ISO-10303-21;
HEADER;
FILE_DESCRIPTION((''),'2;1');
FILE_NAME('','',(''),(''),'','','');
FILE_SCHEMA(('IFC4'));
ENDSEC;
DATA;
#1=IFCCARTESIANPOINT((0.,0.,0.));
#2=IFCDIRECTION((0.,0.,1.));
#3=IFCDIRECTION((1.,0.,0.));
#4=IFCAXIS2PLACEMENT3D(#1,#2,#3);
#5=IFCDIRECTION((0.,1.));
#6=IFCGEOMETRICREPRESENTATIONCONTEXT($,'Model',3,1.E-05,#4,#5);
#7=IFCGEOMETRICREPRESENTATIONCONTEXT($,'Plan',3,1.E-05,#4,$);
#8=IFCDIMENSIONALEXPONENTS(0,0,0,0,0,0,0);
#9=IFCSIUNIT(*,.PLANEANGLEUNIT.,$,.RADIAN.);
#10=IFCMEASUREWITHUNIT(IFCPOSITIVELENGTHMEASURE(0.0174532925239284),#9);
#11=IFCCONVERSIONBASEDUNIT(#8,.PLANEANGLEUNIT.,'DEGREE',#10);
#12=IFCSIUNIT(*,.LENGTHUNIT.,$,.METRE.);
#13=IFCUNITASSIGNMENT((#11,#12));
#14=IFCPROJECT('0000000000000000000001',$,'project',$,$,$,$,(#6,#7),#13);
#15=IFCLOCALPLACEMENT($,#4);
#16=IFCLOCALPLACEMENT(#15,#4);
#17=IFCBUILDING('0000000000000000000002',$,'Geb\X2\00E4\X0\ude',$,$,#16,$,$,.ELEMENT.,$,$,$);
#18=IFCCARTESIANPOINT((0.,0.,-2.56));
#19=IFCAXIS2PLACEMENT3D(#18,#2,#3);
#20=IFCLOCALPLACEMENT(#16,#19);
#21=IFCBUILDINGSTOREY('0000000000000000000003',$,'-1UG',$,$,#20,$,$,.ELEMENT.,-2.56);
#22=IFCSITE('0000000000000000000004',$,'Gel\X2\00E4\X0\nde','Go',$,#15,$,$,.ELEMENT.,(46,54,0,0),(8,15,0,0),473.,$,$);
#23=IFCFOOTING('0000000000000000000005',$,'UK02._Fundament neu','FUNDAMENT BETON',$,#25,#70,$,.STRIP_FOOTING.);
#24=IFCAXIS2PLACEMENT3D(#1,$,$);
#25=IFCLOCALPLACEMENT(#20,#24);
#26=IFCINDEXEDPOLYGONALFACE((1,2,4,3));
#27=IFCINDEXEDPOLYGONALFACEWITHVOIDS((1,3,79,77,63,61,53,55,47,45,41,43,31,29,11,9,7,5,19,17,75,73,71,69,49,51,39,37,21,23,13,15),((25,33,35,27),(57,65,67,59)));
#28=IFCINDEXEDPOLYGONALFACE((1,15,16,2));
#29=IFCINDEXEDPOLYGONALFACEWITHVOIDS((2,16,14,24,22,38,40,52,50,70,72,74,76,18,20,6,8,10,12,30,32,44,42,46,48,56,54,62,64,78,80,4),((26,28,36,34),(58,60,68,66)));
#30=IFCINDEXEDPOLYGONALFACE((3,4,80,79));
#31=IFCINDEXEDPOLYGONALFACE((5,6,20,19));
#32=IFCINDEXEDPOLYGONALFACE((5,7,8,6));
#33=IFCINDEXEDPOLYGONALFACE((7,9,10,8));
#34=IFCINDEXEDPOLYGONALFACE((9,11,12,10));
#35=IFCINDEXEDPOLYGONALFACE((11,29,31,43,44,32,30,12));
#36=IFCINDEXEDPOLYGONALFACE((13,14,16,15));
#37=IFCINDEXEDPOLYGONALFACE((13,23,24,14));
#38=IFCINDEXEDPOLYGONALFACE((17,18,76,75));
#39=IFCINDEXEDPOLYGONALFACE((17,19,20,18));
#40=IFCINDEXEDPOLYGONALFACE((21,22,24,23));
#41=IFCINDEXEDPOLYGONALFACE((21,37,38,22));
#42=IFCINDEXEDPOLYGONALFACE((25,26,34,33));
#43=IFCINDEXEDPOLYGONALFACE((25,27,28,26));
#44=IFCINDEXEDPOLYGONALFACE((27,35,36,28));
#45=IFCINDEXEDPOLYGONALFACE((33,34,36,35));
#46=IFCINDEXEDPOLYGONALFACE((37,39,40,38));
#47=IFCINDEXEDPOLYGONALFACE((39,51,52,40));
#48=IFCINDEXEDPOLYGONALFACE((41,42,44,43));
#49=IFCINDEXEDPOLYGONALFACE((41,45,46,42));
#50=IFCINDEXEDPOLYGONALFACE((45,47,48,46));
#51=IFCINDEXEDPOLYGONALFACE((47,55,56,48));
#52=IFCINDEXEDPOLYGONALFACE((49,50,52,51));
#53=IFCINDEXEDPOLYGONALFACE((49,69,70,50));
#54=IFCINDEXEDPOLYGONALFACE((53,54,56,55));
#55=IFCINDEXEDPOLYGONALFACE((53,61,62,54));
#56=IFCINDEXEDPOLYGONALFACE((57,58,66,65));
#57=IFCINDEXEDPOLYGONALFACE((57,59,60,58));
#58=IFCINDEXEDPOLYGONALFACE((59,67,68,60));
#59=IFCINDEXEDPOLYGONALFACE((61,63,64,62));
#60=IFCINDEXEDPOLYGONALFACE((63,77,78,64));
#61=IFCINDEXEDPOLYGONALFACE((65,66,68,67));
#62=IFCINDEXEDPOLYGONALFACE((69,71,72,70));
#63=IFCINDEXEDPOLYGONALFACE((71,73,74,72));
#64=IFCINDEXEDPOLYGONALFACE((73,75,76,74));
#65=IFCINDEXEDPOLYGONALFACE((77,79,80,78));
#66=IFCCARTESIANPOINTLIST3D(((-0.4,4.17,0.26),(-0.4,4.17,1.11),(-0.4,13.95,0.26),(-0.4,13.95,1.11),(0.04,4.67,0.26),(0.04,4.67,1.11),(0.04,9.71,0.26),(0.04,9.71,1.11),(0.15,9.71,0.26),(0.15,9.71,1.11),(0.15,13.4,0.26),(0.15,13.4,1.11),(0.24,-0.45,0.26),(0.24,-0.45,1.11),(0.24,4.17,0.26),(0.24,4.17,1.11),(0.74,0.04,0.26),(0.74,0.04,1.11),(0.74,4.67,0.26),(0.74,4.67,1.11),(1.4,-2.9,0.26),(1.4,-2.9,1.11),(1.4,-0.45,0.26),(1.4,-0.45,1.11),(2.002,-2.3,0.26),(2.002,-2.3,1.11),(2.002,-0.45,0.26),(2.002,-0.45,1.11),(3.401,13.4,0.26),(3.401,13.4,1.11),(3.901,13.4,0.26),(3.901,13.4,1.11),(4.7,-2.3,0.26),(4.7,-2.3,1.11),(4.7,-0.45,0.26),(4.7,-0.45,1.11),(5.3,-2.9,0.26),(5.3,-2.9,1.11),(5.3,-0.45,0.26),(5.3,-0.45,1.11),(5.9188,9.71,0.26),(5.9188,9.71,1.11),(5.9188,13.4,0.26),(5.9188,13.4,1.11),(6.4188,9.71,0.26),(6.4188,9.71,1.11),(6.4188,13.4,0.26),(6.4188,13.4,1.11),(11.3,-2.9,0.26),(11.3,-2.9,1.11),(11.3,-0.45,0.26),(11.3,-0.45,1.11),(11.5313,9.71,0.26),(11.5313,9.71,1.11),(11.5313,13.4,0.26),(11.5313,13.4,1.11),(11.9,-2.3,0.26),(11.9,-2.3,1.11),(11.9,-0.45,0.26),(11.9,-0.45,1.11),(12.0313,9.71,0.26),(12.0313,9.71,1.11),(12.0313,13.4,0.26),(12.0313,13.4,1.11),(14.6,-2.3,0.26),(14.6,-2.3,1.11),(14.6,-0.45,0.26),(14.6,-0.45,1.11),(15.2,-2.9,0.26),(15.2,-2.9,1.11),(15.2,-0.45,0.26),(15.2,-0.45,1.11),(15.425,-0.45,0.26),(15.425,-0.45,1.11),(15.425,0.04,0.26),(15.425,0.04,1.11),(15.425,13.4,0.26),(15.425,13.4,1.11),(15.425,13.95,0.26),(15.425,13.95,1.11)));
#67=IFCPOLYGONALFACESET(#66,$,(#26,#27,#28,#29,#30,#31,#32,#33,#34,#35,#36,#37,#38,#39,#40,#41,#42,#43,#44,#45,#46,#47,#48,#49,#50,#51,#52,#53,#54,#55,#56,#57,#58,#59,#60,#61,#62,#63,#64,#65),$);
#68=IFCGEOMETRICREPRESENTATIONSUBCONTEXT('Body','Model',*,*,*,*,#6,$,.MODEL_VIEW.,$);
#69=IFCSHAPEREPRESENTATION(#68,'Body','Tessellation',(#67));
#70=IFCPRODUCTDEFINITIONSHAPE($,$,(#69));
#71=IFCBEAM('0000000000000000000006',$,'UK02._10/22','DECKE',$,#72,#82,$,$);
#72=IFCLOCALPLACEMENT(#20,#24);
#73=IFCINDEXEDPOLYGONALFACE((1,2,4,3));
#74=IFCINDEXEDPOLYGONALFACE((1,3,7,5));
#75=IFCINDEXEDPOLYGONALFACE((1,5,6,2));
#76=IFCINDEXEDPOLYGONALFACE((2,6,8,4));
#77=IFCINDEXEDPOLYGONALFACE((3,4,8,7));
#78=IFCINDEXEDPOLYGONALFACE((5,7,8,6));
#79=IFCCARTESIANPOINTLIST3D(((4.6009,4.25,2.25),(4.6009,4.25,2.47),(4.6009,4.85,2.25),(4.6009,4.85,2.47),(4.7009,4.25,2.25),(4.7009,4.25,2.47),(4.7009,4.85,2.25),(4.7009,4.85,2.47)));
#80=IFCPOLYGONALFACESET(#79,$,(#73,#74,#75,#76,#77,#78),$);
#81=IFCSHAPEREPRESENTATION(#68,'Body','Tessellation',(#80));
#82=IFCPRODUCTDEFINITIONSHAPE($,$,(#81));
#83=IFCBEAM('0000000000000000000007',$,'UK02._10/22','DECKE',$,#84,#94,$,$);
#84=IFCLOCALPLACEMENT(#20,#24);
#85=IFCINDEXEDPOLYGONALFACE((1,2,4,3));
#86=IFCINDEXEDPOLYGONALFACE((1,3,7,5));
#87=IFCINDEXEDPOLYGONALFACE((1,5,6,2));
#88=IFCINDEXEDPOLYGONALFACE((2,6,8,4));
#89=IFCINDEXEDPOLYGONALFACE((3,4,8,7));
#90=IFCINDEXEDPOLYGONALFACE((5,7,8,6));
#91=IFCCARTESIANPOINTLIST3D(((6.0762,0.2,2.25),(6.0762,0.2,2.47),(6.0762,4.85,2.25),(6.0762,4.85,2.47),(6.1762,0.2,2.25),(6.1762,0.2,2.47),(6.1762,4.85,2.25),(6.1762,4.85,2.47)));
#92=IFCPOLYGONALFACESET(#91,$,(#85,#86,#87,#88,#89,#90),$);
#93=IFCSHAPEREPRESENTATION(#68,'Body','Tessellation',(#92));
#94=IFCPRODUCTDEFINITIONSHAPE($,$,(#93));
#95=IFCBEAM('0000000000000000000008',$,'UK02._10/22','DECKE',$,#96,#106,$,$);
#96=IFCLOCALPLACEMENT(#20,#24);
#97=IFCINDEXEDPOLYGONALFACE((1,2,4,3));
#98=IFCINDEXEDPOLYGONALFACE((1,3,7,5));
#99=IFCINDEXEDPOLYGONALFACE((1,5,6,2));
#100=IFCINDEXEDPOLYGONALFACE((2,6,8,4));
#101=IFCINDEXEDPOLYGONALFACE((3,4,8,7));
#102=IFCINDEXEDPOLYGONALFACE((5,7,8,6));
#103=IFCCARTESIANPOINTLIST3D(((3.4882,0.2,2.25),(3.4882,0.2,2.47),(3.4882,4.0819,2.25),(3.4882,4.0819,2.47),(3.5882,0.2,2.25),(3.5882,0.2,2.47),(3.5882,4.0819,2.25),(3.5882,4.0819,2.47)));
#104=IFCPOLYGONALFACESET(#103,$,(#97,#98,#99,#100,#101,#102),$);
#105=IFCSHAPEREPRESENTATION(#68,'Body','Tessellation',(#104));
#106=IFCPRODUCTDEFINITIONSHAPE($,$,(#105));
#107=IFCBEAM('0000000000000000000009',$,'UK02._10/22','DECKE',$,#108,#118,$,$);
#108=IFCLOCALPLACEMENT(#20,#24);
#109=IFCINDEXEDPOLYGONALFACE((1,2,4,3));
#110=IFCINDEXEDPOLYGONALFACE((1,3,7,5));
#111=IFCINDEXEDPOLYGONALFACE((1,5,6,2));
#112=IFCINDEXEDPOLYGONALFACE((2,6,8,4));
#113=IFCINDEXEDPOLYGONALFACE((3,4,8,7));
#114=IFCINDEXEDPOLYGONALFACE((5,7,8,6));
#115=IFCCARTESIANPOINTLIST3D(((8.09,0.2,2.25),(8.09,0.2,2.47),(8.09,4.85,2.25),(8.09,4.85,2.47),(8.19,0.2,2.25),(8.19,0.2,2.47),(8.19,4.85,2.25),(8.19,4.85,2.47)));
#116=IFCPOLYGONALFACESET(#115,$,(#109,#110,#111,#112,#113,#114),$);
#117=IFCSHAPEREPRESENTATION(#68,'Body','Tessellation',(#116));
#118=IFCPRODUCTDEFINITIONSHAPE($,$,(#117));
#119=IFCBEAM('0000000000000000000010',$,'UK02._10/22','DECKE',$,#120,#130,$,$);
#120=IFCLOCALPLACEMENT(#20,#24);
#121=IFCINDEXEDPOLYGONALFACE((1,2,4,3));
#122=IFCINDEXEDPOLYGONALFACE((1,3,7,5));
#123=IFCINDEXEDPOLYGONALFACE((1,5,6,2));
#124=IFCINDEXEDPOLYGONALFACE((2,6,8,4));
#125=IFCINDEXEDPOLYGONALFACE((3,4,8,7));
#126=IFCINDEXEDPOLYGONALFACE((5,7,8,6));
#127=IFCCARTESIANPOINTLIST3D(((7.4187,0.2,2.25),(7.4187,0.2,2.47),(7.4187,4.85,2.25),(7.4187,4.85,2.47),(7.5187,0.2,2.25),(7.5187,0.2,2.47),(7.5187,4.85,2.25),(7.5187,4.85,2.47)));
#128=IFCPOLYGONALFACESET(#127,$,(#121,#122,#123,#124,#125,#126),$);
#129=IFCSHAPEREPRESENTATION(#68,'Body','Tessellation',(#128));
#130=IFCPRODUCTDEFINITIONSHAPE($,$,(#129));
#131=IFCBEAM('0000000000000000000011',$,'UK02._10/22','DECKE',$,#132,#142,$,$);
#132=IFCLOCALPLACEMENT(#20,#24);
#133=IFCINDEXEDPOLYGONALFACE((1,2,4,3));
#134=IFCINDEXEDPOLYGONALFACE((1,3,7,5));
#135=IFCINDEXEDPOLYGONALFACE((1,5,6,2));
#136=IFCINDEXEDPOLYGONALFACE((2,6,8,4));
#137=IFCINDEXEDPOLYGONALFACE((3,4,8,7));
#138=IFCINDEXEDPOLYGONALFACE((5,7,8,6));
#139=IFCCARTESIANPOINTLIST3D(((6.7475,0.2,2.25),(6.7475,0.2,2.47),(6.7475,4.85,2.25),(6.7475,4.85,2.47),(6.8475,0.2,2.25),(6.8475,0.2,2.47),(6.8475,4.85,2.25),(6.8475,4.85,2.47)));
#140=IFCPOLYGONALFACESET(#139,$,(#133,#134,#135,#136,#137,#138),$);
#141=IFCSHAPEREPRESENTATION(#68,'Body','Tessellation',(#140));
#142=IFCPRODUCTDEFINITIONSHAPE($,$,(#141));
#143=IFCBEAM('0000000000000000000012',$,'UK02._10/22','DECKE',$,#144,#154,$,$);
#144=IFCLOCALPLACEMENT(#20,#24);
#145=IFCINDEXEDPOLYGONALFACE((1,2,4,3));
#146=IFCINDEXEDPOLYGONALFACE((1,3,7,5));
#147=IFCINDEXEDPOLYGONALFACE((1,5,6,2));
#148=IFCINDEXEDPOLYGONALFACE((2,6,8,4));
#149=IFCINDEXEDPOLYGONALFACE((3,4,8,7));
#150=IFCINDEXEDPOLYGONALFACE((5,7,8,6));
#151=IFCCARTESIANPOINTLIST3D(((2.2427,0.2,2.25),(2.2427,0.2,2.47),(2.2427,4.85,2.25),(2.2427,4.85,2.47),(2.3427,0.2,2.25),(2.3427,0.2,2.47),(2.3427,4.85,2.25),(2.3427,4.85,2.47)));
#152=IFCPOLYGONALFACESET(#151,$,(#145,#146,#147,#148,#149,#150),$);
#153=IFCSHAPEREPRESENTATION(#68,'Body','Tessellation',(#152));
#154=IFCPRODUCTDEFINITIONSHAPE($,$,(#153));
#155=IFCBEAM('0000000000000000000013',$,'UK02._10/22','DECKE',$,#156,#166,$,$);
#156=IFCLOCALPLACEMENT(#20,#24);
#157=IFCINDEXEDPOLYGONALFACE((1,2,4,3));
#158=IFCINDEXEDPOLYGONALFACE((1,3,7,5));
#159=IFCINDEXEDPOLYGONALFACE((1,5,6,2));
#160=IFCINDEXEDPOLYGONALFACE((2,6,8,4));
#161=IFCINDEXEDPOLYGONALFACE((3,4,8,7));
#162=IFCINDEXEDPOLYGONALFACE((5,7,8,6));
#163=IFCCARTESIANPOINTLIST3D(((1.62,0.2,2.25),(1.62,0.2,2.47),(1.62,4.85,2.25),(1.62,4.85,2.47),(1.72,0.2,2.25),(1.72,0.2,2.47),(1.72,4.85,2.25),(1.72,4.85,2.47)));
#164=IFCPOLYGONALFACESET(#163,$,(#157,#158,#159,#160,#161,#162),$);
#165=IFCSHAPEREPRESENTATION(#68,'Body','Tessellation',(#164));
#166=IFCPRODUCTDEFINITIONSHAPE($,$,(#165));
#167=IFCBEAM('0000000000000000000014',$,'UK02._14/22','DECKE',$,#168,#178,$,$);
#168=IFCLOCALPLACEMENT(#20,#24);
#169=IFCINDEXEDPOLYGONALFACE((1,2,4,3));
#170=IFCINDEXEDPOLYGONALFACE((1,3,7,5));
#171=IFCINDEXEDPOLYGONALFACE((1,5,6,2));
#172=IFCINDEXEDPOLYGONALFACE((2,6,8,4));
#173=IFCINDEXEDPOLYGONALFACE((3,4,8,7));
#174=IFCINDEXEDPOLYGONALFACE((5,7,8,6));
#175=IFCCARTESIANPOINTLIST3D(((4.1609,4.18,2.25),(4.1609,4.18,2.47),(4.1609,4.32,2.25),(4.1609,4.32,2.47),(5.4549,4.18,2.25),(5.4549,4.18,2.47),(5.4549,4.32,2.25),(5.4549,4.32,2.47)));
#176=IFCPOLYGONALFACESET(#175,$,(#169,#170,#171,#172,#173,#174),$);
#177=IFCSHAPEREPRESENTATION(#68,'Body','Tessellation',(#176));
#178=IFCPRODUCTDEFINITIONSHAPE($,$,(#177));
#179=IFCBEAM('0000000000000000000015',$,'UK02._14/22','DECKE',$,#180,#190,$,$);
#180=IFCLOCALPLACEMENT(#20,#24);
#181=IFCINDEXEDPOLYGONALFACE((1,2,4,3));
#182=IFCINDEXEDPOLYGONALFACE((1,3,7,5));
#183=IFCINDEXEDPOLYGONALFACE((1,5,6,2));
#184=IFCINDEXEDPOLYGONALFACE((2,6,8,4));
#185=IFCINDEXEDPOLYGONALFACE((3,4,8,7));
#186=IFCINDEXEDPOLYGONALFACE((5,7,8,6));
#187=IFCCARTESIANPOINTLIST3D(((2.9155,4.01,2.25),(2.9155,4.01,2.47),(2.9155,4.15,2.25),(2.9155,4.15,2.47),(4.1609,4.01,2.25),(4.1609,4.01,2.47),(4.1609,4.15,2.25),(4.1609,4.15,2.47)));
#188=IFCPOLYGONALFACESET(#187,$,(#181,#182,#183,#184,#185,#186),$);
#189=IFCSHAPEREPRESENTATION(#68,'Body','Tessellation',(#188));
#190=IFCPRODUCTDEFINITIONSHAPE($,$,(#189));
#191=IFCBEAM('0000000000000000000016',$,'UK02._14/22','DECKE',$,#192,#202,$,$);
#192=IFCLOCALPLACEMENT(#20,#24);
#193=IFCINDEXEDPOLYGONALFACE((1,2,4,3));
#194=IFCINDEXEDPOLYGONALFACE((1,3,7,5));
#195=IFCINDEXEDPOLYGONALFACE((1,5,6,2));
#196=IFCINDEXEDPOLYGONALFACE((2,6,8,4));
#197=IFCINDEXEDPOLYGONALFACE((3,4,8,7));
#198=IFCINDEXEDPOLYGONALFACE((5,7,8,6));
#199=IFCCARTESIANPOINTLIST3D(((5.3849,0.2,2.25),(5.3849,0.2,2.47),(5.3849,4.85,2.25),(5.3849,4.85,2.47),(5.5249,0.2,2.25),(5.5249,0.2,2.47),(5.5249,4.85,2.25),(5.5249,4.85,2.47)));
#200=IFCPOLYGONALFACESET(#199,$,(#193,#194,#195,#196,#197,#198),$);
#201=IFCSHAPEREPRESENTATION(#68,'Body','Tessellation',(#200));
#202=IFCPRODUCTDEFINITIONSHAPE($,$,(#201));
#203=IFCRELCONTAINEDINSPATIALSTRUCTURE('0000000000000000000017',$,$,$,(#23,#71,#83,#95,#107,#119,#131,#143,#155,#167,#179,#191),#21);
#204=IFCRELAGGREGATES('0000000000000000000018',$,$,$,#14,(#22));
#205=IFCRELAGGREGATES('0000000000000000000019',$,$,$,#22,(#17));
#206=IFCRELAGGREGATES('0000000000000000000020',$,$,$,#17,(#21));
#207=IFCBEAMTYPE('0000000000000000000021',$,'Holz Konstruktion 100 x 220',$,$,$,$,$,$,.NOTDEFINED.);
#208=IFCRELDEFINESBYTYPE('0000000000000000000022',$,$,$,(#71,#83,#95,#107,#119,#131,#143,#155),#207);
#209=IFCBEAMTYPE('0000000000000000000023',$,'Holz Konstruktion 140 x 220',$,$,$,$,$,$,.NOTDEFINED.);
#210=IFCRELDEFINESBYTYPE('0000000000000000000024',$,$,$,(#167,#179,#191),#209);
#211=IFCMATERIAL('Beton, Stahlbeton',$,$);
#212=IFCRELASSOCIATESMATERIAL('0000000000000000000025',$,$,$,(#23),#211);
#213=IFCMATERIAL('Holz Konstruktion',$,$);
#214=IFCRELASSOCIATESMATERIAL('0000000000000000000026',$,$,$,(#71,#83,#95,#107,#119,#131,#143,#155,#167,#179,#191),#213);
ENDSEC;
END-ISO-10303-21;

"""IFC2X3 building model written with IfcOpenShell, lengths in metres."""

from ifc_helpers import new_model, entity, si_unit, converted_unit, direction, frame, frame_2d, origin_with_axes, place, context, subcontext, project, spatial, polyline, rectangle, outline, extrude, material, type_object, element, save


model = new_model("IFC2X3")

# Units and contexts
model_context = context("Model", 3, precision=1e-05, world=origin_with_axes(), true_north=direction((0.0, 1.0)))
plan_context = context("Plan", 3, precision=1e-05, world=origin_with_axes())
body_context = subcontext(model_context, "Body", "Model", "MODEL_VIEW")
ifc_project = project(units=[converted_unit("PLANEANGLEUNIT", "DEGREE", entity("IfcPositiveLengthMeasure", 0.0174532925239284), si_unit("PLANEANGLEUNIT", "RADIAN"), dimensions=[0, 0, 0, 0, 0, 0, 0]), si_unit("LENGTHUNIT", "METRE")], contexts=[model_context, plan_context])

# Site, building, storey
site_placement = place(None, origin_with_axes())
site = spatial("IfcSite", under=ifc_project, at=site_placement, Name="Gelände", Description="Go", CompositionType="ELEMENT", RefLatitude=(46, 54, 0, 0), RefLongitude=(8, 15, 0, 0), RefElevation=473.0)
building_placement = place(site_placement, origin_with_axes())
building = spatial("IfcBuilding", under=site, at=building_placement, Name="Gebäude", CompositionType="ELEMENT")
storey_placement = place(building_placement, frame((0.0, 0.0, -2.56), z_axis=(0.0, 0.0, 1.0), x_axis=(1.0, 0.0, 0.0)))
storey = spatial("IfcBuildingStorey", under=building, at=storey_placement, Name="-1UG", CompositionType="ELEMENT", Elevation=-2.56)

# Footing
ifc_material_1 = material(Name="Beton, Stahlbeton")
footing_placement = place(storey_placement, frame((-0.4, 4.17, 1.11), z_axis=(0.0, 0.0, 1.0), x_axis=(1.0, 0.0, 0.0)))
element("IfcFooting", 1, at=footing_placement, inside=storey, material=ifc_material_1, Name="UK02._Fundament neu", Description="FUNDAMENT BETON", PredefinedType="STRIP_FOOTING", context=body_context, shape_type="SweptSolid", body=[
    extrude(outline(polyline([(0.0, 0.0), (0.64, 0.0), (0.64, -4.62), (1.8, -4.62), (1.8, -7.07), (5.7, -7.07), (5.7, -4.62), (11.7, -4.62), (11.7, -7.07), (15.6, -7.07), (15.6, -4.62), (15.825, -4.62), (15.825, -4.13), (1.14, -4.13), (1.14, 0.5), (0.44, 0.5), (0.44, 5.54), (0.55, 5.54), (0.55, 9.23), (3.801, 9.23), (4.301, 9.23), (6.3188, 9.23), (6.3188, 5.54), (6.8188, 5.54), (6.8188, 9.23), (11.9313, 9.23), (11.9313, 5.54), (12.4313, 5.54), (12.4313, 9.23), (15.825, 9.23), (15.825, 9.78), (0.0, 9.78), (0.0, 0.0)]), holes=[polyline([(5.1, -6.47), (2.402, -6.47), (2.402, -4.62), (5.1, -4.62), (5.1, -6.47)]), polyline([(15.0, -6.47), (12.3, -6.47), (12.3, -4.62), (15.0, -4.62), (15.0, -6.47)])]), frame((0.0, 0.0, -0.85), z_axis=(0.0, 0.0, 1.0), x_axis=(1.0, 0.0, 0.0)), (0.0, 0.0, 1.0), 0.85),
])

# Beams
ifc_material_2 = material(Name="Holz Konstruktion")
beam_type_1 = type_object("IfcBeamType", Name="Holz Konstruktion 100 x 220", PredefinedType="NOTDEFINED")
beam_1_placement = place(storey_placement, frame((4.6509, 4.25, 2.47), z_axis=(0.0, 0.0, 1.0), x_axis=(1.0, 0.0, 0.0)))
element("IfcBeam", 2, at=beam_1_placement, inside=storey, type_object=beam_type_1, material=ifc_material_2, Name="UK02._10/22", Description="DECKE", context=body_context, shape_type="SweptSolid", body=[
    extrude(rectangle(XDim=0.22, YDim=0.1, at=frame_2d((-0.11, 0.0), x_axis=(1.0, 0.0))), frame((0.0, 0.0, 0.0), z_axis=(0.0, 1.0, 0.0), x_axis=(0.0, 0.0, 1.0)), (0.0, 0.0, 1.0), 0.6),
])
beam_2_placement = place(storey_placement, frame((6.1262, 0.2, 2.47), z_axis=(0.0, 0.0, 1.0), x_axis=(1.0, 0.0, 0.0)))
element("IfcBeam", 3, at=beam_2_placement, inside=storey, type_object=beam_type_1, material=ifc_material_2, Name="UK02._10/22", Description="DECKE", context=body_context, shape_type="SweptSolid", body=[
    extrude(rectangle(XDim=0.22, YDim=0.1, at=frame_2d((-0.11, 0.0), x_axis=(1.0, 0.0))), frame((0.0, 0.0, 0.0), z_axis=(0.0, 1.0, 0.0), x_axis=(0.0, 0.0, 1.0)), (0.0, 0.0, 1.0), 4.65),
])
beam_3_placement = place(storey_placement, frame((3.5382, 0.2, 2.47), z_axis=(0.0, 0.0, 1.0), x_axis=(1.0, 0.0, 0.0)))
element("IfcBeam", 4, at=beam_3_placement, inside=storey, type_object=beam_type_1, material=ifc_material_2, Name="UK02._10/22", Description="DECKE", context=body_context, shape_type="SweptSolid", body=[
    extrude(rectangle(XDim=0.22, YDim=0.1, at=frame_2d((-0.11, 0.0), x_axis=(1.0, 0.0))), frame((0.0, 0.0, 0.0), z_axis=(0.0, 1.0, 0.0), x_axis=(0.0, 0.0, 1.0)), (0.0, 0.0, 1.0), 3.8819),
])
for number, where, z_axis, x_axis, name in (
    (5, (8.14, 0.2, 2.47), (0.0, 0.0, 1.0), (1.0, 0.0, 0.0), "UK02._10/22"),
    (6, (7.4687, 0.2, 2.47), (0.0, 0.0, 1.0), (1.0, 0.0, 0.0), "UK02._10/22"),
    (7, (6.7975, 0.2, 2.47), (0.0, 0.0, 1.0), (1.0, 0.0, 0.0), "UK02._10/22"),
    (8, (2.2927, 0.2, 2.47), (0.0, 0.0, 1.0), (1.0, 0.0, 0.0), "UK02._10/22"),
    (9, (1.67, 0.2, 2.47), (0.0, 0.0, 1.0), (1.0, 0.0, 0.0), "UK02._10/22"),
):
    element("IfcBeam", number, at=place(storey_placement, frame(where, z_axis=z_axis, x_axis=x_axis)), inside=storey, type_object=beam_type_1, material=ifc_material_2, Name=name, Description="DECKE", context=body_context, shape_type="SweptSolid", body=[
        extrude(rectangle(XDim=0.22, YDim=0.1, at=frame_2d((-0.11, 0.0), x_axis=(1.0, 0.0))), frame((0.0, 0.0, 0.0), z_axis=(0.0, 1.0, 0.0), x_axis=(0.0, 0.0, 1.0)), (0.0, 0.0, 1.0), 4.65),
    ])
beam_type_2 = type_object("IfcBeamType", Name="Holz Konstruktion 140 x 220", PredefinedType="NOTDEFINED")
beam_4_placement = place(storey_placement, frame((4.1609, 4.25, 2.47), z_axis=(0.0, 0.0, 1.0), x_axis=(0.0, -1.0, 0.0)))
element("IfcBeam", 10, at=beam_4_placement, inside=storey, type_object=beam_type_2, material=ifc_material_2, Name="UK02._14/22", Description="DECKE", context=body_context, shape_type="SweptSolid", body=[
    extrude(rectangle(XDim=0.22, YDim=0.14, at=frame_2d((-0.11, 0.0), x_axis=(1.0, 0.0))), frame((0.0, 0.0, 0.0), z_axis=(0.0, 1.0, 0.0), x_axis=(0.0, 0.0, 1.0)), (0.0, 0.0, 1.0), 1.294),
])
beam_5_placement = place(storey_placement, frame((2.9155, 4.08, 2.47), z_axis=(0.0, 0.0, 1.0), x_axis=(0.0, -1.0, 0.0)))
element("IfcBeam", 11, at=beam_5_placement, inside=storey, type_object=beam_type_2, material=ifc_material_2, Name="UK02._14/22", Description="DECKE", context=body_context, shape_type="SweptSolid", body=[
    extrude(rectangle(XDim=0.22, YDim=0.14, at=frame_2d((-0.11, 0.0), x_axis=(1.0, 0.0))), frame((0.0, 0.0, 0.0), z_axis=(0.0, 1.0, 0.0), x_axis=(0.0, 0.0, 1.0)), (0.0, 0.0, 1.0), 1.2454),
])
for number, where, z_axis, x_axis, name in (
    (12, (5.4549, 0.2, 2.47), (0.0, 0.0, 1.0), (1.0, 0.0, 0.0), "UK02._14/22"),
):
    element("IfcBeam", number, at=place(storey_placement, frame(where, z_axis=z_axis, x_axis=x_axis)), inside=storey, type_object=beam_type_2, material=ifc_material_2, Name=name, Description="DECKE", context=body_context, shape_type="SweptSolid", body=[
        extrude(rectangle(XDim=0.22, YDim=0.14, at=frame_2d((-0.11, 0.0), x_axis=(1.0, 0.0))), frame((0.0, 0.0, 0.0), z_axis=(0.0, 1.0, 0.0), x_axis=(0.0, 0.0, 1.0)), (0.0, 0.0, 1.0), 4.65),
    ])

save(model, "model.ifc")
